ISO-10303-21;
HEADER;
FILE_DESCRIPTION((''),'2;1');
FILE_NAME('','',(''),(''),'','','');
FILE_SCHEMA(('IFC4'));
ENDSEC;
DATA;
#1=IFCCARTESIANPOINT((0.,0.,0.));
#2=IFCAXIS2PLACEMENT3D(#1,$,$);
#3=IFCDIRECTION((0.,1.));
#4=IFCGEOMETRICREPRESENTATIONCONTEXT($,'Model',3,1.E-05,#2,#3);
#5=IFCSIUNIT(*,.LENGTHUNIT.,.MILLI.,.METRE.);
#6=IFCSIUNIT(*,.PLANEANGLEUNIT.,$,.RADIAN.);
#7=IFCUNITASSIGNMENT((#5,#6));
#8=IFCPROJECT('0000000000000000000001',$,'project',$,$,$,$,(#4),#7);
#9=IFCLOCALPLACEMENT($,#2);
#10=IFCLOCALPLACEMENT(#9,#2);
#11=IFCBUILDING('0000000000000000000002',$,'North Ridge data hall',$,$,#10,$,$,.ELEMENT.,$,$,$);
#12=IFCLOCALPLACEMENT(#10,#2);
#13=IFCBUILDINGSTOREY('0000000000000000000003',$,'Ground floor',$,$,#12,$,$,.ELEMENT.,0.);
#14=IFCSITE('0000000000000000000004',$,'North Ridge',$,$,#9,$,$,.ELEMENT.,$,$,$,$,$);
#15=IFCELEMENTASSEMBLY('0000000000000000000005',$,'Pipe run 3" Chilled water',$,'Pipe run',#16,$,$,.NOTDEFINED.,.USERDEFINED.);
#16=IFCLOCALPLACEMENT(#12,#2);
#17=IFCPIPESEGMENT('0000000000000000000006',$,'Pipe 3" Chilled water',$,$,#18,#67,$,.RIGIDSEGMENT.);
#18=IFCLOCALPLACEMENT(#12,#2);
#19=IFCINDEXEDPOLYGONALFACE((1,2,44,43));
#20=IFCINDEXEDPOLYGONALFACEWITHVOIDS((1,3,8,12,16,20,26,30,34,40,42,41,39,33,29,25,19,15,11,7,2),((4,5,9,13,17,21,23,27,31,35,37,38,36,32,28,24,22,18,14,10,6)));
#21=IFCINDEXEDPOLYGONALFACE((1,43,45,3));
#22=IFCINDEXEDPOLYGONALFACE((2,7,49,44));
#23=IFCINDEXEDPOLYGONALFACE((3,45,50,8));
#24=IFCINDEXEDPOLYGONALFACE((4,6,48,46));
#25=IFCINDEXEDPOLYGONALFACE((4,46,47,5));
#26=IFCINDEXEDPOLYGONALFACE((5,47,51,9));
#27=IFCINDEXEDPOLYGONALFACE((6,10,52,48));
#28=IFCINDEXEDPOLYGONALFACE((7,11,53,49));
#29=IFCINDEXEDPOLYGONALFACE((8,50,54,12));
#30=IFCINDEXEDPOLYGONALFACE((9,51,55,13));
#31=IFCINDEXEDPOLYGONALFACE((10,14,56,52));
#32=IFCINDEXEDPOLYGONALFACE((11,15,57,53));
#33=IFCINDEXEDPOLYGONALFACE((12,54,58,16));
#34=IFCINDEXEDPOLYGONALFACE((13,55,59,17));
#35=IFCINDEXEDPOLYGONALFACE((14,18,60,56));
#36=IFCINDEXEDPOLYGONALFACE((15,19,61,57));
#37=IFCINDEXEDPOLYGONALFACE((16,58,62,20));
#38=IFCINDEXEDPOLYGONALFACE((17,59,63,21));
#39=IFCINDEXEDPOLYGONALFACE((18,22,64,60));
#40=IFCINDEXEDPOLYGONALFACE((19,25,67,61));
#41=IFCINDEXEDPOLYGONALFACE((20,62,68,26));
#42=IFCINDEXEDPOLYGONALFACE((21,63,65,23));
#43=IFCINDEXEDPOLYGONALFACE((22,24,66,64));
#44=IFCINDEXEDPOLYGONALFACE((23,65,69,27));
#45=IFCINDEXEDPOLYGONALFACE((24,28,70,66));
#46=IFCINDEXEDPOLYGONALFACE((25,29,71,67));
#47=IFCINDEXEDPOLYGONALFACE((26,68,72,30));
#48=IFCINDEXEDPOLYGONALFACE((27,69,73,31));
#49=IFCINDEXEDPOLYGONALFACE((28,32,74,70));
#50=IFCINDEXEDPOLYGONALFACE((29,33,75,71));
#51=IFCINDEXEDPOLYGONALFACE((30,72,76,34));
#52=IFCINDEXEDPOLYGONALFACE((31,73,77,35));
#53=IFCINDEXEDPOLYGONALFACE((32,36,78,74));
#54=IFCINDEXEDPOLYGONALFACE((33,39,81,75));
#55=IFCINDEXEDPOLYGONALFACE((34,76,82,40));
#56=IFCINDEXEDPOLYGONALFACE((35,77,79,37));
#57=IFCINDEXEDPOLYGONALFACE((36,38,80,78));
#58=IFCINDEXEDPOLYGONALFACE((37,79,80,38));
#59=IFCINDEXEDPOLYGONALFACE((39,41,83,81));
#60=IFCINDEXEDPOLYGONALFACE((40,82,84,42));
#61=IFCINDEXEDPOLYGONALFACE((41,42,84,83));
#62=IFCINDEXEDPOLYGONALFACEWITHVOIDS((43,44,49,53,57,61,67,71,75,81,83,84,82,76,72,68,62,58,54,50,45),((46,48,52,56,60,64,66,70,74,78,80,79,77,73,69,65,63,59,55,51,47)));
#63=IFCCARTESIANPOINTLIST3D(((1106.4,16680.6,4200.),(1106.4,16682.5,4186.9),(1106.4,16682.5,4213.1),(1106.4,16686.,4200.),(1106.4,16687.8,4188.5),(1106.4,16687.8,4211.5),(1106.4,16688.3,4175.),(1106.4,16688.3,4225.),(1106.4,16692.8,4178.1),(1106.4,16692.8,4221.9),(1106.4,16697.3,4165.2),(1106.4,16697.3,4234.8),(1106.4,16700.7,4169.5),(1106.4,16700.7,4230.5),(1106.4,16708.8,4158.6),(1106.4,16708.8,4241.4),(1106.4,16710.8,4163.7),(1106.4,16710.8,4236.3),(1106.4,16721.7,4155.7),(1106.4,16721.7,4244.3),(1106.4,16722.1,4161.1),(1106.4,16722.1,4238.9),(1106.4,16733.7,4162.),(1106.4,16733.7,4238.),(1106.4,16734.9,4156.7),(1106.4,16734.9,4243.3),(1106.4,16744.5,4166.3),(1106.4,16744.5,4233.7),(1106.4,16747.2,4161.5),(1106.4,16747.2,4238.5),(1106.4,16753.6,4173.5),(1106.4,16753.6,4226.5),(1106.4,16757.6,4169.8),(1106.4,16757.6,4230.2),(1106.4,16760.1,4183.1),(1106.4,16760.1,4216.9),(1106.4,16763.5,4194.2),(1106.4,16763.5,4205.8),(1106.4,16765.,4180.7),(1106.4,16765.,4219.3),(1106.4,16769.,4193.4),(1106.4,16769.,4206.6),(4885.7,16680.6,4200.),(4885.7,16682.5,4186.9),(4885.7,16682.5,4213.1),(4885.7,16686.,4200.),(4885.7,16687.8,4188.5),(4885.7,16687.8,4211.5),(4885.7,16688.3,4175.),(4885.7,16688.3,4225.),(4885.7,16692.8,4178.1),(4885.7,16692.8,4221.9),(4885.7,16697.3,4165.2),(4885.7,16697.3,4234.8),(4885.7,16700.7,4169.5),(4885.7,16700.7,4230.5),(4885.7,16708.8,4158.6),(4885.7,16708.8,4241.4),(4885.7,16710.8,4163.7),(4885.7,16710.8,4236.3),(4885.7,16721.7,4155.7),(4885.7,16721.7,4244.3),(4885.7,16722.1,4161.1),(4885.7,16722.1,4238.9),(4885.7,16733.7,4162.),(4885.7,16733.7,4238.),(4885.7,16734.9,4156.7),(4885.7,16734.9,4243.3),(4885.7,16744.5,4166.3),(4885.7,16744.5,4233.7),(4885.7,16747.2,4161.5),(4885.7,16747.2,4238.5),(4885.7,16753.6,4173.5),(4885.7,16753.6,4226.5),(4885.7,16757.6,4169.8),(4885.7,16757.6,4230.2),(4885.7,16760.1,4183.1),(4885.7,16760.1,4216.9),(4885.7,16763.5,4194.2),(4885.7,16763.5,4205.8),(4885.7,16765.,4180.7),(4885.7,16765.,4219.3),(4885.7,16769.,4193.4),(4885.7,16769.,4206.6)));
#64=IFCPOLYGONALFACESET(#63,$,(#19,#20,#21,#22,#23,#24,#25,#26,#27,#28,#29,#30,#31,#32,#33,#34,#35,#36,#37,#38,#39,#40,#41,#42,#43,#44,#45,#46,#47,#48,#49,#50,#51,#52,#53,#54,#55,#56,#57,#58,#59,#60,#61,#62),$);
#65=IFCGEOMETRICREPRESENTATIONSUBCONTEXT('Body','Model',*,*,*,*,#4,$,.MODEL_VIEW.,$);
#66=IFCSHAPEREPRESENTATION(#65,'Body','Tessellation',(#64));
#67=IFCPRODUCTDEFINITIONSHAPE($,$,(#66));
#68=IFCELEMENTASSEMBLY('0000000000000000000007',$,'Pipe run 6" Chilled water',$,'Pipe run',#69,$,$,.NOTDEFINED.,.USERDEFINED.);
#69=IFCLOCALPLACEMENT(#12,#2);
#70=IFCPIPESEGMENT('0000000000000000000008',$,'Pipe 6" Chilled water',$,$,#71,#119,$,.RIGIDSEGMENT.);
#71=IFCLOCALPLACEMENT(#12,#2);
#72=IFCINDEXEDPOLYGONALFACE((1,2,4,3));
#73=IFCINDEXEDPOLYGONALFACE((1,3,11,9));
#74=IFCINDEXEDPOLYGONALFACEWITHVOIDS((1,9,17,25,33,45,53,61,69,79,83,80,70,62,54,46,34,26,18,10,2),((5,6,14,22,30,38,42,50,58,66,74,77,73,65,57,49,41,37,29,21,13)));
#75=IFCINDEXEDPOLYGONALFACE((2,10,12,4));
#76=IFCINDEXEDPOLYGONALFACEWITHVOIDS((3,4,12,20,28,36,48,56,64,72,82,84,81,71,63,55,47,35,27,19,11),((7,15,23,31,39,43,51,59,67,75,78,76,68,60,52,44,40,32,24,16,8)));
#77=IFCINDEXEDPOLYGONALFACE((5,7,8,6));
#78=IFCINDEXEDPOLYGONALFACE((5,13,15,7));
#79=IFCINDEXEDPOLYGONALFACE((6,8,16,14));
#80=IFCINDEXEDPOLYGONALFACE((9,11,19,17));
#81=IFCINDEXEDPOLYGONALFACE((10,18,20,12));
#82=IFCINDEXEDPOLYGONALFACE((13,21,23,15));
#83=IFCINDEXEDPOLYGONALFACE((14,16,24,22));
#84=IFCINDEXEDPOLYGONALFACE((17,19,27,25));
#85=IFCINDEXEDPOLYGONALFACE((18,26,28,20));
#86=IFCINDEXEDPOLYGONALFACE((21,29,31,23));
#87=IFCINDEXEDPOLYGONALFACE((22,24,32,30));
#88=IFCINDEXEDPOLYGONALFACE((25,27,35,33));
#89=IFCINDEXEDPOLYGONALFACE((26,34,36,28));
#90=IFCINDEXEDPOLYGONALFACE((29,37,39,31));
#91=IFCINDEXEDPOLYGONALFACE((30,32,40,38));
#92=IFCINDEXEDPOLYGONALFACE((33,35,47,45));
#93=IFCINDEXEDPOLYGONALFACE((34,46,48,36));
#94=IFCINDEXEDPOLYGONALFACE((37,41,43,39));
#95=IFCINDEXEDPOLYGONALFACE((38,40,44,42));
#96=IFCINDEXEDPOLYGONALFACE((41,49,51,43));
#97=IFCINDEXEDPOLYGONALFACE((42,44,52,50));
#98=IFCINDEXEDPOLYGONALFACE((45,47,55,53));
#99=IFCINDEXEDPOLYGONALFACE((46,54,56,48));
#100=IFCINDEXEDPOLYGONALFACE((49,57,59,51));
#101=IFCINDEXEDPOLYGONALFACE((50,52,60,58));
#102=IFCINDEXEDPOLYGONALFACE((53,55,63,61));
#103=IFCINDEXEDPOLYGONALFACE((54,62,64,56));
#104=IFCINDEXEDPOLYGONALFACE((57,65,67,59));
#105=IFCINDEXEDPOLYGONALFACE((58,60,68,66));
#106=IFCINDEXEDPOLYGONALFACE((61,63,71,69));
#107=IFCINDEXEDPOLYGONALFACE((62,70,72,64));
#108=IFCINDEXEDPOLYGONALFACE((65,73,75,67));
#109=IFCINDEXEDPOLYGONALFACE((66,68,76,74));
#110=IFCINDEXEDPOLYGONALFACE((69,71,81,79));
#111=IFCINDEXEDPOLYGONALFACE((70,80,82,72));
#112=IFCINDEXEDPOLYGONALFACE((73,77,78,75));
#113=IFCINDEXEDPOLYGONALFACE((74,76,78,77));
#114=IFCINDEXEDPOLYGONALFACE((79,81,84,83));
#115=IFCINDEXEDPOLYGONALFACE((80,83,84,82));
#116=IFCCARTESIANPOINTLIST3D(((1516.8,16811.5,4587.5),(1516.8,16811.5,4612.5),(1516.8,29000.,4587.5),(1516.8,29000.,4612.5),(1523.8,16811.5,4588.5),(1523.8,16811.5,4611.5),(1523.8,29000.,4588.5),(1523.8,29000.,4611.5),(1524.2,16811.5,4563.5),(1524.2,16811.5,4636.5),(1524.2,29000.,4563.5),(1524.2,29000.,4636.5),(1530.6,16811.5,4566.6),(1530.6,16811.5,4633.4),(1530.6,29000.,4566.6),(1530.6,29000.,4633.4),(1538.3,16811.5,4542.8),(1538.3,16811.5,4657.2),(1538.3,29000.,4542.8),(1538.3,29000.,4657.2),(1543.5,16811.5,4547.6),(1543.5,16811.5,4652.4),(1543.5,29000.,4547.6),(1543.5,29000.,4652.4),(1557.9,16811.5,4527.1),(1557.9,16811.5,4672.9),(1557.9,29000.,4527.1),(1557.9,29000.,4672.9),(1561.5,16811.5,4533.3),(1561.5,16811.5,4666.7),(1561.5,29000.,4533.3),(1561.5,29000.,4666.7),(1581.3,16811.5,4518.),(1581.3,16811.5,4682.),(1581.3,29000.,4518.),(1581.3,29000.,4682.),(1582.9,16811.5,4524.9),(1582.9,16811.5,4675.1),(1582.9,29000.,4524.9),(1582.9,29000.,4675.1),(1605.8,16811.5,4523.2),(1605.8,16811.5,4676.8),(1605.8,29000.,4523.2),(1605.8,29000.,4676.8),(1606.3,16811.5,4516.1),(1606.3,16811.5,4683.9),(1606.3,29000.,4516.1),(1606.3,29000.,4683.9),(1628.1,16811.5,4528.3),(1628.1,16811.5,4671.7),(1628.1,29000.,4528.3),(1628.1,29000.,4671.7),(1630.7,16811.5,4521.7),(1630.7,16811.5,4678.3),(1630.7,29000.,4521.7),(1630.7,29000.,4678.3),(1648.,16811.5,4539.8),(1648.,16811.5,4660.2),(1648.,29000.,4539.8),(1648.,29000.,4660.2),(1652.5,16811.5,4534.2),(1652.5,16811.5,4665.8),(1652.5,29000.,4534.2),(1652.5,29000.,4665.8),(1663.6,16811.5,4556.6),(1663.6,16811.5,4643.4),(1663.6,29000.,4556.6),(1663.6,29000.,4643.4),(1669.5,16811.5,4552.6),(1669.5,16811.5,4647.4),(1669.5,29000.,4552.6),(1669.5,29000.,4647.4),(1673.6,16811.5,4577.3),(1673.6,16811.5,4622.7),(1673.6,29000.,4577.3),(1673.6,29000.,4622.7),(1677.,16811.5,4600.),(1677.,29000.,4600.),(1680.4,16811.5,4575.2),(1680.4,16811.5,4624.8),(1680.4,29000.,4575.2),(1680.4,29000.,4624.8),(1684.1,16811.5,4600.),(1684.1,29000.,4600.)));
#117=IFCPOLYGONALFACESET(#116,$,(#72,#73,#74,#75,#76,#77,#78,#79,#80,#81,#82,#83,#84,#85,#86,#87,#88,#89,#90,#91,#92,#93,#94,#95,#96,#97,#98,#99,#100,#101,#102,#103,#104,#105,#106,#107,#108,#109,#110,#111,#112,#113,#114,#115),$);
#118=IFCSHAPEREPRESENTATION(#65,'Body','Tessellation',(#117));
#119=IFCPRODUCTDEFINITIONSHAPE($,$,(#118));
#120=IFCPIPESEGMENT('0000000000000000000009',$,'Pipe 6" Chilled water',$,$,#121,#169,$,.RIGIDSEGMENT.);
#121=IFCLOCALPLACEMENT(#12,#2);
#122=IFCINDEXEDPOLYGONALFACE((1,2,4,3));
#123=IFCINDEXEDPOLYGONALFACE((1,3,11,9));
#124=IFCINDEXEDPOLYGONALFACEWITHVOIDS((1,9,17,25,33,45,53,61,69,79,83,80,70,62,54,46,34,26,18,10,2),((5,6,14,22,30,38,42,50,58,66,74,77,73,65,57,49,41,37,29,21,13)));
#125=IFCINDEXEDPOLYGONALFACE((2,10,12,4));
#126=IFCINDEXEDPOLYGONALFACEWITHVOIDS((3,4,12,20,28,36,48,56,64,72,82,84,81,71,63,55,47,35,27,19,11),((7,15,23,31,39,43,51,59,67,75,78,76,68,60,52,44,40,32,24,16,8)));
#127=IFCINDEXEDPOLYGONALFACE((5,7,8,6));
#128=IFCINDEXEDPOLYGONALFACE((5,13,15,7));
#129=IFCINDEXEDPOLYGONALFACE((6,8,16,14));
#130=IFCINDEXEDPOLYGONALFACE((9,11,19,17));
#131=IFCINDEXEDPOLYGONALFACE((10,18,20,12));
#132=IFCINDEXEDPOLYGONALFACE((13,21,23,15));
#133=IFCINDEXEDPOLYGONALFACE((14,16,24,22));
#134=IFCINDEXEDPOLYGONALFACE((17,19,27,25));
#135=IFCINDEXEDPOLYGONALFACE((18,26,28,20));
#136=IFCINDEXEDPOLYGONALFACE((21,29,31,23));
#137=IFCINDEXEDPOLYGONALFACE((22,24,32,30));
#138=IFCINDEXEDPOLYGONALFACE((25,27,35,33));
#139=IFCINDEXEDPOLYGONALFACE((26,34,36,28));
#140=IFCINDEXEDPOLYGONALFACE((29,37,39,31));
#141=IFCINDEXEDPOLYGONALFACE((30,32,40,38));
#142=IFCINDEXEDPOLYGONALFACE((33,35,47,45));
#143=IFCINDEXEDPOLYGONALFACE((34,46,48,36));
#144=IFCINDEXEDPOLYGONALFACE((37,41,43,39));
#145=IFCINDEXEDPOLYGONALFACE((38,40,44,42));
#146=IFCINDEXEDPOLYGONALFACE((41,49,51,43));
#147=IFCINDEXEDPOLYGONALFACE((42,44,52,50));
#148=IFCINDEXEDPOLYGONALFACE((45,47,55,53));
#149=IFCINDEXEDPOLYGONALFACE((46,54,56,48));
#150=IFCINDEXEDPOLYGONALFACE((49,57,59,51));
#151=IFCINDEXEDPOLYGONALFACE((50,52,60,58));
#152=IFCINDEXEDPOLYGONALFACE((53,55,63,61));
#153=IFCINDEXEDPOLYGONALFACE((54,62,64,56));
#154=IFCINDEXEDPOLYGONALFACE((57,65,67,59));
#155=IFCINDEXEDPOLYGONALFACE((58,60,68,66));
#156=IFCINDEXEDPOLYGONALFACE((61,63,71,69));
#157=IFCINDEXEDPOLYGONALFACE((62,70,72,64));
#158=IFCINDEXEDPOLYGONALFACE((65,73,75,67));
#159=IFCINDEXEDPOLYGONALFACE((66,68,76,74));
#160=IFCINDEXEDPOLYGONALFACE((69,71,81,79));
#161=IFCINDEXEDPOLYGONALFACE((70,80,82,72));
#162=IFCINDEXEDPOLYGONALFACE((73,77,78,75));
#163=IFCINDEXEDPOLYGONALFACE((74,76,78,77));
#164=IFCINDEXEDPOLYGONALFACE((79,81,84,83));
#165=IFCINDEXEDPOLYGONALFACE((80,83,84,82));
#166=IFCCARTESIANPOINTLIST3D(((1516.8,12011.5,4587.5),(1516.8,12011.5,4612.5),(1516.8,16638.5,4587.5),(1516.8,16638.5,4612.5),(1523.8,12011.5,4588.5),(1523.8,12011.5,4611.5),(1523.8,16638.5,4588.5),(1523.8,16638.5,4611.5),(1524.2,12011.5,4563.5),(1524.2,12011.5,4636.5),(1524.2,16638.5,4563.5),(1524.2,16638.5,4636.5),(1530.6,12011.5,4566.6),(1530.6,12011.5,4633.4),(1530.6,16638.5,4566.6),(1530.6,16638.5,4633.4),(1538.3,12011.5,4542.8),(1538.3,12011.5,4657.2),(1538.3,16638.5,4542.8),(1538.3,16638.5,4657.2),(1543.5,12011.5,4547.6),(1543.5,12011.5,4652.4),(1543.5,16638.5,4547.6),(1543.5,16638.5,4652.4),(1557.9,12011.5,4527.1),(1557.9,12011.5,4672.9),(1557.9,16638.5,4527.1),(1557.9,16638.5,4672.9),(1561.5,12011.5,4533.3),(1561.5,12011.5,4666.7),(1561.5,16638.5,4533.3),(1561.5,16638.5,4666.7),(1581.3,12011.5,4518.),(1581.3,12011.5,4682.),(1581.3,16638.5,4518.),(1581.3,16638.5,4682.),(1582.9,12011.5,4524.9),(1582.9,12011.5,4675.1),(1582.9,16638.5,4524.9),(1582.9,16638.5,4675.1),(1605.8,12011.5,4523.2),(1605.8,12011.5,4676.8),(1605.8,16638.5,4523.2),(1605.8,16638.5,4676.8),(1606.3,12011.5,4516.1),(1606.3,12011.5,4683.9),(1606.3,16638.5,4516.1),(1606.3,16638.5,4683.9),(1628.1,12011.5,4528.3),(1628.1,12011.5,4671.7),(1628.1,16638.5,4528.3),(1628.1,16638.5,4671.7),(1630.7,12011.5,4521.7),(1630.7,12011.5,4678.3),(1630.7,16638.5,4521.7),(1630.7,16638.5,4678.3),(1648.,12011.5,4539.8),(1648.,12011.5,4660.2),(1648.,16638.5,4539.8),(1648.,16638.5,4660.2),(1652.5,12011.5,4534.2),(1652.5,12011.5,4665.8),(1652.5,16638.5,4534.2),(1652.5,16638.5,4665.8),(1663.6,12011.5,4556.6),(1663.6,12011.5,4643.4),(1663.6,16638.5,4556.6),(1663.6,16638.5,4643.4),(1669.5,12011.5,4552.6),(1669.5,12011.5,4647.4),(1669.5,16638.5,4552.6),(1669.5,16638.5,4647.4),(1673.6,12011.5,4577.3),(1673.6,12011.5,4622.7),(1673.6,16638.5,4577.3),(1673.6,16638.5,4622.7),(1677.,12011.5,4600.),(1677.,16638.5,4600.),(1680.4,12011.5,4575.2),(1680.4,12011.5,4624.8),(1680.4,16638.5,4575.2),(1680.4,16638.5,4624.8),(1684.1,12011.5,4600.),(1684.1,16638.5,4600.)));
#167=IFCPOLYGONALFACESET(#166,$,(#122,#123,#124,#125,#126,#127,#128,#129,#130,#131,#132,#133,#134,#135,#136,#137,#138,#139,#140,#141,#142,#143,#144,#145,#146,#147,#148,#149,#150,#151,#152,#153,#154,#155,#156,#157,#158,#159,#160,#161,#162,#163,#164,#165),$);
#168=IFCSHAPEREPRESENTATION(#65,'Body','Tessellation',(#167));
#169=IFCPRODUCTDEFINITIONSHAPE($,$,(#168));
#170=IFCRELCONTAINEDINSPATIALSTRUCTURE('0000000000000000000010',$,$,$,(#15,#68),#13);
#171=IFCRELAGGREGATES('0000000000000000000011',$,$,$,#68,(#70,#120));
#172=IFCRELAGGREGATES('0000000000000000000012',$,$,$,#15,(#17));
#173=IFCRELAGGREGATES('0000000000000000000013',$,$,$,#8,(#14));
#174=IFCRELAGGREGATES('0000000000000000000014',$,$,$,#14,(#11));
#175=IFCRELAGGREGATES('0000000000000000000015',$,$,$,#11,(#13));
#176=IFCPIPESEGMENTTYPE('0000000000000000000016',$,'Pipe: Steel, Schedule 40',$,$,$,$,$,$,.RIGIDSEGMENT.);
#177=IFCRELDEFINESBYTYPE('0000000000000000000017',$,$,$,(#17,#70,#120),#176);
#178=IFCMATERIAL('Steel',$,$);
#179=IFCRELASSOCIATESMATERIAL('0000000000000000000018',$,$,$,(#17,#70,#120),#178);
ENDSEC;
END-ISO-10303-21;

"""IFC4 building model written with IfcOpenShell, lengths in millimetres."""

from ifc_helpers import new_model, si_unit, direction, frame, origin, origin_with_axes, origin_2d, place, context, subcontext, project, spatial, hollow_circle, extrude, material, type_object, element, aggregate, save


model = new_model("IFC4")

# Units and contexts
model_context = context("Model", 3, precision=1e-05, world=origin(), true_north=direction((0.0, 1.0)))
body_context = subcontext(model_context, "Body", "Model", "MODEL_VIEW")
ifc_project = project(units=[si_unit("LENGTHUNIT", "METRE", prefix="MILLI"), si_unit("PLANEANGLEUNIT", "RADIAN")], contexts=[model_context])

# Site, building, storey
site_placement = place(None, origin())
site = spatial("IfcSite", under=ifc_project, at=site_placement, Name="North Ridge", CompositionType="ELEMENT")
building_placement = place(site_placement, origin())
building = spatial("IfcBuilding", under=site, at=building_placement, Name="North Ridge data hall", CompositionType="ELEMENT")
storey_placement = place(building_placement, origin())
storey = spatial("IfcBuildingStorey", under=building, at=storey_placement, Name="Ground floor", CompositionType="ELEMENT", Elevation=0.0)

# Element assemblies, pipe segments
ifc_material_1 = material(Name="Steel")
pipe_segment_type = type_object("IfcPipeSegmentType", Name="Pipe: Steel, Schedule 40", PredefinedType="RIGIDSEGMENT")
assembly_1_placement = place(storey_placement, origin_with_axes())
assembly_1 = element("IfcElementAssembly", 1, at=assembly_1_placement, inside=storey, Name="Pipe run 3\" Chilled water", ObjectType="Pipe run", AssemblyPlace="NOTDEFINED", PredefinedType="USERDEFINED")
pipe_segment_1_placement = place(storey_placement, origin_with_axes())
pipe_segment_1 = element("IfcPipeSegment", 2, at=pipe_segment_1_placement, type_object=pipe_segment_type, material=ifc_material_1, Name="Pipe 3\" Chilled water", PredefinedType="RIGIDSEGMENT", context=body_context, shape_type="SweptSolid", body=[
    extrude(hollow_circle(Radius=44.5, WallThickness=5.5, at=origin_2d()), frame((4885.7, 16725.0, 4200.0), z_axis=(-1.0, 0.0, 0.0), x_axis=(0.0, -1.0, 0.0)), (0.0, 0.0, 1.0), 3779.3),
])
assembly_2_placement = place(storey_placement, origin_with_axes())
assembly_2 = element("IfcElementAssembly", 3, at=assembly_2_placement, inside=storey, Name="Pipe run 6\" Chilled water", ObjectType="Pipe run", AssemblyPlace="NOTDEFINED", PredefinedType="USERDEFINED")
pipe_segment_2_placement = place(storey_placement, origin_with_axes())
pipe_segment_2 = element("IfcPipeSegment", 4, at=pipe_segment_2_placement, type_object=pipe_segment_type, material=ifc_material_1, Name="Pipe 6\" Chilled water", PredefinedType="RIGIDSEGMENT", context=body_context, shape_type="SweptSolid", body=[
    extrude(hollow_circle(Radius=84.1, WallThickness=7.1, at=origin_2d()), frame((1600.0, 29000.0, 4600.0), z_axis=(0.0, -1.0, 0.0), x_axis=(1.0, 0.0, 0.0)), (0.0, 0.0, 1.0), 12188.5),
])
pipe_segment_3_placement = place(storey_placement, origin_with_axes())
pipe_segment_3 = element("IfcPipeSegment", 5, at=pipe_segment_3_placement, type_object=pipe_segment_type, material=ifc_material_1, Name="Pipe 6\" Chilled water", PredefinedType="RIGIDSEGMENT", context=body_context, shape_type="SweptSolid", body=[
    extrude(hollow_circle(Radius=84.1, WallThickness=7.1, at=origin_2d()), frame((1600.0, 16638.5, 4600.0), z_axis=(0.0, -1.0, 0.0), x_axis=(1.0, 0.0, 0.0)), (0.0, 0.0, 1.0), 4627.0),
])

aggregate(assembly_2, [pipe_segment_2, pipe_segment_3])
aggregate(assembly_1, [pipe_segment_1])

save(model, "model.ifc")
